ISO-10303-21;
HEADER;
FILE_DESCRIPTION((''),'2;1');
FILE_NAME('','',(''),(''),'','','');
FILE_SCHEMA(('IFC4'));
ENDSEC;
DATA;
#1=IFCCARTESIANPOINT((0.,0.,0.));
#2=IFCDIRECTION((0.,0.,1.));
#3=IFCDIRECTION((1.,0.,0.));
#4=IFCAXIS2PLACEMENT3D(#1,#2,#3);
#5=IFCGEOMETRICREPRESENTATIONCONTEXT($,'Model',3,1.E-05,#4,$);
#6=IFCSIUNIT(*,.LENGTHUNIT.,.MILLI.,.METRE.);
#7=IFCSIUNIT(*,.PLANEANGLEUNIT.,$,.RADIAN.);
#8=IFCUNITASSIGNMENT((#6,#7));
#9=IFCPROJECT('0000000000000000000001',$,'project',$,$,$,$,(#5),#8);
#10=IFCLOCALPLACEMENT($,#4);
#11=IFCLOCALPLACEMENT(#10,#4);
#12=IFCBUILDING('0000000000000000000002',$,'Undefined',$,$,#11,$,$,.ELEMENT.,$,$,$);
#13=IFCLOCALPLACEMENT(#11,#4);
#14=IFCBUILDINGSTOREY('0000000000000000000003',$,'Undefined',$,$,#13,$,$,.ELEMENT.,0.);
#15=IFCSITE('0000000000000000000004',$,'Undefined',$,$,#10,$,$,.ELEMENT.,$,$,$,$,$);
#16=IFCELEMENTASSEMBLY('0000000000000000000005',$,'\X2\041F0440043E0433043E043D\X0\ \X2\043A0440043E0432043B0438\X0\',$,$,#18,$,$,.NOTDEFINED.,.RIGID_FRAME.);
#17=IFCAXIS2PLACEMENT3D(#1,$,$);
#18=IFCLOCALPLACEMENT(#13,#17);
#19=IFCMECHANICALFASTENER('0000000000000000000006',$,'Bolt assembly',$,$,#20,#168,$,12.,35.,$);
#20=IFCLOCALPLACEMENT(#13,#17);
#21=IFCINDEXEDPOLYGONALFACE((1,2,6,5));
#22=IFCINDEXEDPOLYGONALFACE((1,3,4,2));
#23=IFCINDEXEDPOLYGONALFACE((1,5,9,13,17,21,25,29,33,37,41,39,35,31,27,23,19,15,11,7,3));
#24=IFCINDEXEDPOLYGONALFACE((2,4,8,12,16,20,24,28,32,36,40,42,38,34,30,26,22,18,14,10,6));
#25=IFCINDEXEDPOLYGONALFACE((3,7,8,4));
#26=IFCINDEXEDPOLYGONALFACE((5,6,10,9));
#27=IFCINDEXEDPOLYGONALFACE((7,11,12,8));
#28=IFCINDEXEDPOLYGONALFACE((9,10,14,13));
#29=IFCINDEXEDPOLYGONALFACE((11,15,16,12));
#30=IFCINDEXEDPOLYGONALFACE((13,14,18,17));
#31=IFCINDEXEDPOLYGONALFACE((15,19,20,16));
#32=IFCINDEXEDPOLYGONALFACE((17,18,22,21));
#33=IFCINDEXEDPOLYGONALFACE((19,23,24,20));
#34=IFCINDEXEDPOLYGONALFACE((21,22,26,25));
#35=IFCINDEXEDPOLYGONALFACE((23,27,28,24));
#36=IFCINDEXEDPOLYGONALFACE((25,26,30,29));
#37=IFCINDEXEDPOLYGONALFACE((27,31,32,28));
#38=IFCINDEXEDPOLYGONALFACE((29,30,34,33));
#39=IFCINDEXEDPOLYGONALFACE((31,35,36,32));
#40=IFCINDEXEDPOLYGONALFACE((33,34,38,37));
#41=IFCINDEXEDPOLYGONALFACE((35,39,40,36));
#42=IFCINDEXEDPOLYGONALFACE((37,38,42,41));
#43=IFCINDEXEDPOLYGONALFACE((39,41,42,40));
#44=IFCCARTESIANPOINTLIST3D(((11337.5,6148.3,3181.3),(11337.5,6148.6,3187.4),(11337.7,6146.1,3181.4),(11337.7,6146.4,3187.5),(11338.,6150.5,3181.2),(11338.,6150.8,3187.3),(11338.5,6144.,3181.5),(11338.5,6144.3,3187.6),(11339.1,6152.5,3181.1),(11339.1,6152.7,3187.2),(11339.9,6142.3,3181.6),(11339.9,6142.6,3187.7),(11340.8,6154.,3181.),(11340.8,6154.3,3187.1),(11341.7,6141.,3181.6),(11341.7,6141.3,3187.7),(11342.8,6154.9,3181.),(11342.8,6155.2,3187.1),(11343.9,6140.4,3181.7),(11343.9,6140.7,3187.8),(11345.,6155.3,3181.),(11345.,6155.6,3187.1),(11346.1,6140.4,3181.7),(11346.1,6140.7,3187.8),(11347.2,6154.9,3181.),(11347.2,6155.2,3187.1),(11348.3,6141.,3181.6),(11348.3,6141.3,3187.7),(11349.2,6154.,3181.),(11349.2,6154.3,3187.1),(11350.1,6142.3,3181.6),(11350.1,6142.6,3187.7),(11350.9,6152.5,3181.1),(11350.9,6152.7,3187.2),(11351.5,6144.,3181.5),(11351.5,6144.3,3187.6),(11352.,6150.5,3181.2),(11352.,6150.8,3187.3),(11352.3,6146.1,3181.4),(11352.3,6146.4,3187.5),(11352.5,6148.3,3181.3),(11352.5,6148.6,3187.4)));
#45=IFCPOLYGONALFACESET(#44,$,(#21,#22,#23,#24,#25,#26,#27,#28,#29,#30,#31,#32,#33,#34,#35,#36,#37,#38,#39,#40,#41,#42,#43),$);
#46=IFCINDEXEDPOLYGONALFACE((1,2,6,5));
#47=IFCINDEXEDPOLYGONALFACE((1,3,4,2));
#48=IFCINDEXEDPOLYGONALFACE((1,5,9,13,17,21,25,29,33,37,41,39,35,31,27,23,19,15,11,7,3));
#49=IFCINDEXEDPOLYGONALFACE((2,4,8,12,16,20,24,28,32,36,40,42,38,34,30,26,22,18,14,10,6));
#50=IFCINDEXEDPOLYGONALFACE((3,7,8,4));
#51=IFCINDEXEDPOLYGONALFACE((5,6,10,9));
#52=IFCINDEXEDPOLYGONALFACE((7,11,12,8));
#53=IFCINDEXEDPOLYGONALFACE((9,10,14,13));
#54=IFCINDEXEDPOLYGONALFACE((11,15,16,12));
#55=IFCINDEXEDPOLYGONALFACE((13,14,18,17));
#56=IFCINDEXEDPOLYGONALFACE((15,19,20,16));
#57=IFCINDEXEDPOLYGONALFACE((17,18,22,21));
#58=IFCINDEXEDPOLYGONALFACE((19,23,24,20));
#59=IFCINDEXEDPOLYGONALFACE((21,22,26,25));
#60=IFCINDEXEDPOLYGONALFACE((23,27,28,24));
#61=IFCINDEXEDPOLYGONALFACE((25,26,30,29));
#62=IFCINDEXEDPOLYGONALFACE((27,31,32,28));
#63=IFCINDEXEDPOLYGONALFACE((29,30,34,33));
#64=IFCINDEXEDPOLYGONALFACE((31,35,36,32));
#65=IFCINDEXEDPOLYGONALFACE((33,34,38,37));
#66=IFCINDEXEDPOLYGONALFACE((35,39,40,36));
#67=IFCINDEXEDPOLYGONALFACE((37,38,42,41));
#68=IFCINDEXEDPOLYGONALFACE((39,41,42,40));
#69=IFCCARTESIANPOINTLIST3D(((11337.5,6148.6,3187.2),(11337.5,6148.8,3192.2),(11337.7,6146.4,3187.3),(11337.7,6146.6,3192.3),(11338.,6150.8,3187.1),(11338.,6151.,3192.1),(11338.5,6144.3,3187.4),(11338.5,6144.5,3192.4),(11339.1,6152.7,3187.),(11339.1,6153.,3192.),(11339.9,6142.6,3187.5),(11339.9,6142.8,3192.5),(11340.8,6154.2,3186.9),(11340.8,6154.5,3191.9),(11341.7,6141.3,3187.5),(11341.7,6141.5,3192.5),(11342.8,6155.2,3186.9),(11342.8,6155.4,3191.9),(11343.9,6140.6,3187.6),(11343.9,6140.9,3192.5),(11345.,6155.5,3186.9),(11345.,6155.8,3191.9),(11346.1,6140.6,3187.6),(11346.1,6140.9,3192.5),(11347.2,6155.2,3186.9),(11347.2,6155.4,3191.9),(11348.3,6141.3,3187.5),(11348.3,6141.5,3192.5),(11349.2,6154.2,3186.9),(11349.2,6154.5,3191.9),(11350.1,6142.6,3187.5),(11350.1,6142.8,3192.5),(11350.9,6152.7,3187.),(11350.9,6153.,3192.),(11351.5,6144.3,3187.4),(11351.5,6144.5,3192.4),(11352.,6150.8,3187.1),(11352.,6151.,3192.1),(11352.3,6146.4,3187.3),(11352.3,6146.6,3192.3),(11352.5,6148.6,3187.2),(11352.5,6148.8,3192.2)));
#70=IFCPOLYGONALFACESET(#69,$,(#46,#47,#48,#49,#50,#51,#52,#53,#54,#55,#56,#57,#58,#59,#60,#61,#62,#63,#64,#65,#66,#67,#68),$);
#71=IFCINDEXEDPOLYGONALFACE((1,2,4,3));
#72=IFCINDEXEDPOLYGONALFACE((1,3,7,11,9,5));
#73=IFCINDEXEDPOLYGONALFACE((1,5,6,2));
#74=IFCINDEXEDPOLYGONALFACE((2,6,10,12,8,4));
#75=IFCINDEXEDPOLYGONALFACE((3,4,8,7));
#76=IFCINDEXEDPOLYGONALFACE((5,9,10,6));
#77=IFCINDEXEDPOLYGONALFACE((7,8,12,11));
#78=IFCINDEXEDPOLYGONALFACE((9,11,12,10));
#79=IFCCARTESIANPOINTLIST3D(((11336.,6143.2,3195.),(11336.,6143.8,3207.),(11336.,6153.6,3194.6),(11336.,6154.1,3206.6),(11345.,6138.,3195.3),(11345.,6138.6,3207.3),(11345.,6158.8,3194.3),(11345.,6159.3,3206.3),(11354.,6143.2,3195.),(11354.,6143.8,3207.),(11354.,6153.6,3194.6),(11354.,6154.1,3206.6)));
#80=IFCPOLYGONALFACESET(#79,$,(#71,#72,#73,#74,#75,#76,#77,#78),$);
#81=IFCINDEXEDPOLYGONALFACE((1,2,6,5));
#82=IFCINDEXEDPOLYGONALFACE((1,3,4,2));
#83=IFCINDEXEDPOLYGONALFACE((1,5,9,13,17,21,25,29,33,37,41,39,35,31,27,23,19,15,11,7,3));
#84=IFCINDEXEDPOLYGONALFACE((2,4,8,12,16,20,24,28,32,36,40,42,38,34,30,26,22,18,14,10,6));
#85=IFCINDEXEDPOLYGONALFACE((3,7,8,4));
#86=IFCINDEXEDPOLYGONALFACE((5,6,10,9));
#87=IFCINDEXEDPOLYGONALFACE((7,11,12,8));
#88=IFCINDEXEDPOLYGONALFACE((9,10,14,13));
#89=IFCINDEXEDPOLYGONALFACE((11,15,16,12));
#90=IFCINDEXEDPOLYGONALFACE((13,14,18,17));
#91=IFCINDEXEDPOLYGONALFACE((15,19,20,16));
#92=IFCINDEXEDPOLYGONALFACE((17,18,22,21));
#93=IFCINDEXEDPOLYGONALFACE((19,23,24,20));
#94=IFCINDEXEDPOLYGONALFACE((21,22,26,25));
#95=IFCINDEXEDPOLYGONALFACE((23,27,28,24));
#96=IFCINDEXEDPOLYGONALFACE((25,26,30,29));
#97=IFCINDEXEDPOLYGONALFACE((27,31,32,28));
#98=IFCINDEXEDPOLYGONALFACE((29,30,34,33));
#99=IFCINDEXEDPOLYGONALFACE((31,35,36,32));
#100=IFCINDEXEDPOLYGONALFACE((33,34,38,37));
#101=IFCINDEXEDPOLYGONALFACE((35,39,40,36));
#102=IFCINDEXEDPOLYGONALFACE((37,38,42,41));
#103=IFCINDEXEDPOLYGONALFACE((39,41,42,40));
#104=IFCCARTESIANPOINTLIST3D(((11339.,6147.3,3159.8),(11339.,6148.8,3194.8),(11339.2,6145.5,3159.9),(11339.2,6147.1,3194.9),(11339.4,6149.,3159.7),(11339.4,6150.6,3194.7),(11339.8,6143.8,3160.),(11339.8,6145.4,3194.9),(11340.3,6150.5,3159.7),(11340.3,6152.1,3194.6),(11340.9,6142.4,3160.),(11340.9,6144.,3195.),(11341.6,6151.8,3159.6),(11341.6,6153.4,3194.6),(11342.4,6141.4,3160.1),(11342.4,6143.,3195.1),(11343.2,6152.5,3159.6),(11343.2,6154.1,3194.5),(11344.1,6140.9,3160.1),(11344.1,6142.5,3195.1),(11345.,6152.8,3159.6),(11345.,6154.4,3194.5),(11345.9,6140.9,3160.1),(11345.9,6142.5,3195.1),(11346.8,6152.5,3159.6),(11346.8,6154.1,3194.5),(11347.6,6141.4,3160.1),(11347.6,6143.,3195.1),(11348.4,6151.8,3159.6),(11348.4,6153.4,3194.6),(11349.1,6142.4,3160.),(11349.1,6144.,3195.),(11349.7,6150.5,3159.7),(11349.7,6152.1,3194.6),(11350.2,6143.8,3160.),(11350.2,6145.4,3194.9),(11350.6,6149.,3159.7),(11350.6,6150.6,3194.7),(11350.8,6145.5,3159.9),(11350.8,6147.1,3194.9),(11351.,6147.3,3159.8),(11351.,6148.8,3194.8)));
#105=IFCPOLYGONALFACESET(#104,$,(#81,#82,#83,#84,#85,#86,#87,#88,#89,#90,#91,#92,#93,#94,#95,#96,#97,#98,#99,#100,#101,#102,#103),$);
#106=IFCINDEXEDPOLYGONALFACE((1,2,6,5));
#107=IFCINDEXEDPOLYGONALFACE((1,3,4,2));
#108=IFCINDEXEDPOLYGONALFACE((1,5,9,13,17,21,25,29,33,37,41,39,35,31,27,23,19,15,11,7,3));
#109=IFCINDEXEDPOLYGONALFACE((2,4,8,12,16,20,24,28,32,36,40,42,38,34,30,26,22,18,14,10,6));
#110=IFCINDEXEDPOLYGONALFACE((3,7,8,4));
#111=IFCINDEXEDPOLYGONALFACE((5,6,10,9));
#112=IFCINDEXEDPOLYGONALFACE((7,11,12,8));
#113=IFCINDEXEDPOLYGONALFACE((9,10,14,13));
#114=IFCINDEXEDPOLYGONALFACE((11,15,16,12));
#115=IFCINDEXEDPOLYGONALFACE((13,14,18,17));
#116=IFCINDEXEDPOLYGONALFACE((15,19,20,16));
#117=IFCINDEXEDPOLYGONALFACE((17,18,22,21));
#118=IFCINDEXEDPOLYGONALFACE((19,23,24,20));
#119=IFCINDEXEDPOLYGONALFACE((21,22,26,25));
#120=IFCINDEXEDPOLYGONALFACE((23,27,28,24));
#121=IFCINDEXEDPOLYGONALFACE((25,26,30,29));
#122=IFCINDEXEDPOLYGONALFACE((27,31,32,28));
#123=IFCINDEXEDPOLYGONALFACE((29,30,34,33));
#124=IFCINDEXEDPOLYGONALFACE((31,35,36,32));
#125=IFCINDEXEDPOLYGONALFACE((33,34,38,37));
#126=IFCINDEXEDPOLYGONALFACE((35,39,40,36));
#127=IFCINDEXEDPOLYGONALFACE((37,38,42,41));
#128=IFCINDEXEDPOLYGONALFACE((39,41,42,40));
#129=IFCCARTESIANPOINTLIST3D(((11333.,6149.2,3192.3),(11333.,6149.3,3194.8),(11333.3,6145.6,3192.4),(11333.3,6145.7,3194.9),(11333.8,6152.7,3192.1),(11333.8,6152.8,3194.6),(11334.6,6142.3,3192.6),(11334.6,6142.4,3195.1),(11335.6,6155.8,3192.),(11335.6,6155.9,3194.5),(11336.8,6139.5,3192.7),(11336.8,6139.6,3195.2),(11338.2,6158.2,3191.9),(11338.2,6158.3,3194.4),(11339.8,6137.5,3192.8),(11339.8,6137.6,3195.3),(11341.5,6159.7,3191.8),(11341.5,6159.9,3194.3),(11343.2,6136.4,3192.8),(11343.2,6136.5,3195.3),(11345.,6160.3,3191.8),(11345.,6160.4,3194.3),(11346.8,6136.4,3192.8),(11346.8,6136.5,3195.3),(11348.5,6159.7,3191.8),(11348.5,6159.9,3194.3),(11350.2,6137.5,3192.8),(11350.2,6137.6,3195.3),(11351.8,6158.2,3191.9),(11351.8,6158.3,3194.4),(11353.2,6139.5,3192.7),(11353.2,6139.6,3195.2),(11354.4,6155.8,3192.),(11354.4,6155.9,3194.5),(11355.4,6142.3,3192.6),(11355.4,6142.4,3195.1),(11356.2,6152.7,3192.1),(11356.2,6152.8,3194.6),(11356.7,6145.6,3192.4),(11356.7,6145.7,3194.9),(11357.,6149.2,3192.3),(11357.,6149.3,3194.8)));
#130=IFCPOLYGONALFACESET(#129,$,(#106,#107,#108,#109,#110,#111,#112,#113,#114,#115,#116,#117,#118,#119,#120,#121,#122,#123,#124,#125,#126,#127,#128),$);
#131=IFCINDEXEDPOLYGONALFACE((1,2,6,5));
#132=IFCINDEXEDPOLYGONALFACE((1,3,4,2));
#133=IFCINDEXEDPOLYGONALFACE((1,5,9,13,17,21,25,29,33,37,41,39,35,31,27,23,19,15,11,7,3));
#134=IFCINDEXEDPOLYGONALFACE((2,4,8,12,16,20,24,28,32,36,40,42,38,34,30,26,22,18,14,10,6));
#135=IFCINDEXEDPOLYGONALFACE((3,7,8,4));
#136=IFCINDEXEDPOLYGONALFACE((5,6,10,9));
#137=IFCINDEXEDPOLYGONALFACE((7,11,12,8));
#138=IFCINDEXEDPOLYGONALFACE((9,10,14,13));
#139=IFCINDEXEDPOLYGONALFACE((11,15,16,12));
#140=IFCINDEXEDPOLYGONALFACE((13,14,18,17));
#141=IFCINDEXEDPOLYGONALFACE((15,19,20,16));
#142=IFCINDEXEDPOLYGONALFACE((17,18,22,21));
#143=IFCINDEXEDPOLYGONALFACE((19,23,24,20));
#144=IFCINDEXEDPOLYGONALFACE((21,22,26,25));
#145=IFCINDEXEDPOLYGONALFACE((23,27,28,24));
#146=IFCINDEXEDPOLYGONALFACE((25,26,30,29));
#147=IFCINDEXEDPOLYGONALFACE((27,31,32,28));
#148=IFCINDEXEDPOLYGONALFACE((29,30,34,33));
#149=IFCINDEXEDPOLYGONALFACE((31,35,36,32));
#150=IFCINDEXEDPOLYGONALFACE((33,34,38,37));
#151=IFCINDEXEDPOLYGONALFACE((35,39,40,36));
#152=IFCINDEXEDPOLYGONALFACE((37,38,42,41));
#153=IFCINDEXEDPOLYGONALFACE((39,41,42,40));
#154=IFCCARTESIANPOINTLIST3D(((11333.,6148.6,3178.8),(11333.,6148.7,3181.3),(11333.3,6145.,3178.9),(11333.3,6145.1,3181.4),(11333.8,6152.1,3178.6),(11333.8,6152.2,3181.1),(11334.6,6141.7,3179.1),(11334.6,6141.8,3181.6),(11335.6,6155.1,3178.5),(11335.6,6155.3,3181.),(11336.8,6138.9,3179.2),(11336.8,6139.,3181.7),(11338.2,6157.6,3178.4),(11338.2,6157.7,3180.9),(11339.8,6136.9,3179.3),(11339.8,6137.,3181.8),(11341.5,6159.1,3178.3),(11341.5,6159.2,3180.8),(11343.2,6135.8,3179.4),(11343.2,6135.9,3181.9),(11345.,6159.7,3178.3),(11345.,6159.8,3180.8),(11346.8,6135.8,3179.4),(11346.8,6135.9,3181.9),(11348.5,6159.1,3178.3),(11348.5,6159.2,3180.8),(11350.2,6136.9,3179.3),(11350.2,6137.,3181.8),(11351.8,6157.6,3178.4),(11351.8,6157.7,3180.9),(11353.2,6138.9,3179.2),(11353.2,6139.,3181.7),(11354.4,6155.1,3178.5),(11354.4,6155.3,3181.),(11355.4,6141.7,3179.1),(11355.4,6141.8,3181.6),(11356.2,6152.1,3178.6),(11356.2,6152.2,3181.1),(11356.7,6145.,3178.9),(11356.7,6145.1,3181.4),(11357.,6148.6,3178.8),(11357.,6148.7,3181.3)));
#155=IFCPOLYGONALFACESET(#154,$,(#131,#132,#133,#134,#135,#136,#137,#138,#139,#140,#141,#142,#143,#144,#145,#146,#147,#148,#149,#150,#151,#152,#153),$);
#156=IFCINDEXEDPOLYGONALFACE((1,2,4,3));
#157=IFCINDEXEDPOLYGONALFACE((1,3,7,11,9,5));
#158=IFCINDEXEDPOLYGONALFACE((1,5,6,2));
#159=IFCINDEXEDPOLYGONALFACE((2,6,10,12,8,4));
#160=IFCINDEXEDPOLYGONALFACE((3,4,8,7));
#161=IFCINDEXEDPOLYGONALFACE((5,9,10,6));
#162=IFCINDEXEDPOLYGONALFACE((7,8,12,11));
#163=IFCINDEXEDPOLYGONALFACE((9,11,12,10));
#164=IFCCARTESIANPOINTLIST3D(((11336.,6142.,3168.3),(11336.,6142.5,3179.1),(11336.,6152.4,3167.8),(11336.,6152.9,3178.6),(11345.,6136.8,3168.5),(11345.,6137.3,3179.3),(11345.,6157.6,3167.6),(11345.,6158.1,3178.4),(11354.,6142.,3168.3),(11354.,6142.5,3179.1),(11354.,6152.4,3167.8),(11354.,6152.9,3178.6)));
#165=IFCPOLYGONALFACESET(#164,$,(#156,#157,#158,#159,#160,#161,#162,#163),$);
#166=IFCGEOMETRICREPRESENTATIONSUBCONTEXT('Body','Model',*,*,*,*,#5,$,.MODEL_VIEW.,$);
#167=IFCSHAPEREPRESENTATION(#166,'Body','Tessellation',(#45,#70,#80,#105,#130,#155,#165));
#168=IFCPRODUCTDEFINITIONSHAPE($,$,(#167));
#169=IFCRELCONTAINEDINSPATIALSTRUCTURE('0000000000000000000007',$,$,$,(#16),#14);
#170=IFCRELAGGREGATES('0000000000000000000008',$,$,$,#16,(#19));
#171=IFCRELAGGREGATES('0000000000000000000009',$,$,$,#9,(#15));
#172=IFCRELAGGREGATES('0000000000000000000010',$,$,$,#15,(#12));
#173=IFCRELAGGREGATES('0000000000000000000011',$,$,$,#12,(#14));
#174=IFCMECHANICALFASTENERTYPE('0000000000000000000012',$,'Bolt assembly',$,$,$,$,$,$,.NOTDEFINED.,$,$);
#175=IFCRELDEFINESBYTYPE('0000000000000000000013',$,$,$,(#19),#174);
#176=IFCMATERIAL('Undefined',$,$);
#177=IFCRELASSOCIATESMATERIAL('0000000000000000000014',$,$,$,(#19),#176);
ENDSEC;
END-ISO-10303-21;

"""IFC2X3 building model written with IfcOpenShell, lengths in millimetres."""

from ifc_helpers import new_model, si_unit, frame, origin_with_axes, origin_2d_with_axis, place, context, subcontext, project, spatial, polyline, circle, outline, extrude, source, transform, mapped, material, type_object, element, aggregate, save


model = new_model("IFC2X3")

# Units and contexts
model_context = context("Model", 3, precision=1e-05, world=origin_with_axes())
body_context = subcontext(model_context, "Body", "Model", "MODEL_VIEW")
ifc_project = project(units=[si_unit("LENGTHUNIT", "METRE", prefix="MILLI"), si_unit("PLANEANGLEUNIT", "RADIAN")], contexts=[model_context])

# Site, building, storey
site_placement = place(None, origin_with_axes())
site = spatial("IfcSite", under=ifc_project, at=site_placement, Name="Undefined", CompositionType="ELEMENT")
building_placement = place(site_placement, origin_with_axes())
building = spatial("IfcBuilding", under=site, at=building_placement, Name="Undefined", CompositionType="ELEMENT")
storey_placement = place(building_placement, origin_with_axes())
storey = spatial("IfcBuildingStorey", under=building, at=storey_placement, Name="Undefined", CompositionType="ELEMENT", Elevation=0.0)

# Element assembly
assembly_1_placement = place(storey_placement, origin_with_axes())
assembly_1 = element("IfcElementAssembly", 1, at=assembly_1_placement, inside=storey, Name="Прогон кровли", AssemblyPlace="NOTDEFINED", PredefinedType="RIGID_FRAME")

# Mechanical fastener
ifc_material_1 = material(Name="Undefined")
mechanical_fastener_type = type_object("IfcMechanicalFastenerType", Name="Bolt assembly")
shared_shape_1 = source(origin_with_axes(), body_context, "Body", "SweptSolid", [
    extrude(circle(Radius=7.5, at=origin_2d_with_axis()), frame((0.0, -0.1, 0.0), z_axis=(0.0, 1.0, 0.0), x_axis=(1.0, 0.0, 0.0)), (0.0, 0.0, 1.0), 6.1),
    extrude(circle(Radius=7.5, at=origin_2d_with_axis()), frame((0.0, -4.9, 0.0), z_axis=(0.0, 1.0, 0.0), x_axis=(1.0, 0.0, 0.0)), (0.0, 0.0, 1.0), 5.0),
    extrude(outline(polyline([(10.4, 0.0), (5.2, 9.0), (-5.2, 9.0), (-10.4, 0.0), (-5.2, -9.0), (5.2, -9.0), (10.4, 0.0)])), frame((0.0, -19.5, 0.0), z_axis=(0.0, 1.0, 0.0), x_axis=(1.0, 0.0, 0.0)), (0.0, 0.0, 1.0), 12.0),
    extrude(circle(Radius=6.0, at=origin_2d_with_axis()), frame((0.0, -7.5, 0.0), z_axis=(0.0, 1.0, 0.0), x_axis=(1.0, 0.0, 0.0)), (0.0, 0.0, 1.0), 35.0),
    extrude(circle(Radius=12.0, at=origin_2d_with_axis()), frame((0.0, -7.5, 0.0), z_axis=(0.0, 1.0, 0.0), x_axis=(1.0, 0.0, 0.0)), (0.0, 0.0, 1.0), 2.5),
    extrude(circle(Radius=12.0, at=origin_2d_with_axis()), frame((0.0, 6.0, 0.0), z_axis=(0.0, 1.0, 0.0), x_axis=(1.0, 0.0, 0.0)), (0.0, 0.0, 1.0), 2.5),
    extrude(outline(polyline([(10.4, 0.0), (5.2, 9.0), (-5.2, 9.0), (-10.4, 0.0), (-5.2, -9.0), (5.2, -9.0), (10.4, 0.0)])), frame((0.0, 8.5, 0.0), z_axis=(0.0, 1.0, 0.0), x_axis=(1.0, 0.0, 0.0)), (0.0, 0.0, 1.0), 10.8),
])
mechanical_fastener_1_placement = place(assembly_1_placement, frame((11345.0, 6148.1, 3187.3), z_axis=(-1.0, 0.0, 0.0), x_axis=(0.0, 0.998969, -0.045408)))
mechanical_fastener_1 = element("IfcMechanicalFastener", 2, at=mechanical_fastener_1_placement, type_object=mechanical_fastener_type, material=ifc_material_1, Name="Bolt assembly", NominalDiameter=12.0, NominalLength=35.0, context=body_context, shape_type="MappedRepresentation", body=[
    mapped(shared_shape_1, transform((0.0, 0.0, 0.0))),
])
aggregate(assembly_1, [mechanical_fastener_1])

save(model, "model.ifc")
